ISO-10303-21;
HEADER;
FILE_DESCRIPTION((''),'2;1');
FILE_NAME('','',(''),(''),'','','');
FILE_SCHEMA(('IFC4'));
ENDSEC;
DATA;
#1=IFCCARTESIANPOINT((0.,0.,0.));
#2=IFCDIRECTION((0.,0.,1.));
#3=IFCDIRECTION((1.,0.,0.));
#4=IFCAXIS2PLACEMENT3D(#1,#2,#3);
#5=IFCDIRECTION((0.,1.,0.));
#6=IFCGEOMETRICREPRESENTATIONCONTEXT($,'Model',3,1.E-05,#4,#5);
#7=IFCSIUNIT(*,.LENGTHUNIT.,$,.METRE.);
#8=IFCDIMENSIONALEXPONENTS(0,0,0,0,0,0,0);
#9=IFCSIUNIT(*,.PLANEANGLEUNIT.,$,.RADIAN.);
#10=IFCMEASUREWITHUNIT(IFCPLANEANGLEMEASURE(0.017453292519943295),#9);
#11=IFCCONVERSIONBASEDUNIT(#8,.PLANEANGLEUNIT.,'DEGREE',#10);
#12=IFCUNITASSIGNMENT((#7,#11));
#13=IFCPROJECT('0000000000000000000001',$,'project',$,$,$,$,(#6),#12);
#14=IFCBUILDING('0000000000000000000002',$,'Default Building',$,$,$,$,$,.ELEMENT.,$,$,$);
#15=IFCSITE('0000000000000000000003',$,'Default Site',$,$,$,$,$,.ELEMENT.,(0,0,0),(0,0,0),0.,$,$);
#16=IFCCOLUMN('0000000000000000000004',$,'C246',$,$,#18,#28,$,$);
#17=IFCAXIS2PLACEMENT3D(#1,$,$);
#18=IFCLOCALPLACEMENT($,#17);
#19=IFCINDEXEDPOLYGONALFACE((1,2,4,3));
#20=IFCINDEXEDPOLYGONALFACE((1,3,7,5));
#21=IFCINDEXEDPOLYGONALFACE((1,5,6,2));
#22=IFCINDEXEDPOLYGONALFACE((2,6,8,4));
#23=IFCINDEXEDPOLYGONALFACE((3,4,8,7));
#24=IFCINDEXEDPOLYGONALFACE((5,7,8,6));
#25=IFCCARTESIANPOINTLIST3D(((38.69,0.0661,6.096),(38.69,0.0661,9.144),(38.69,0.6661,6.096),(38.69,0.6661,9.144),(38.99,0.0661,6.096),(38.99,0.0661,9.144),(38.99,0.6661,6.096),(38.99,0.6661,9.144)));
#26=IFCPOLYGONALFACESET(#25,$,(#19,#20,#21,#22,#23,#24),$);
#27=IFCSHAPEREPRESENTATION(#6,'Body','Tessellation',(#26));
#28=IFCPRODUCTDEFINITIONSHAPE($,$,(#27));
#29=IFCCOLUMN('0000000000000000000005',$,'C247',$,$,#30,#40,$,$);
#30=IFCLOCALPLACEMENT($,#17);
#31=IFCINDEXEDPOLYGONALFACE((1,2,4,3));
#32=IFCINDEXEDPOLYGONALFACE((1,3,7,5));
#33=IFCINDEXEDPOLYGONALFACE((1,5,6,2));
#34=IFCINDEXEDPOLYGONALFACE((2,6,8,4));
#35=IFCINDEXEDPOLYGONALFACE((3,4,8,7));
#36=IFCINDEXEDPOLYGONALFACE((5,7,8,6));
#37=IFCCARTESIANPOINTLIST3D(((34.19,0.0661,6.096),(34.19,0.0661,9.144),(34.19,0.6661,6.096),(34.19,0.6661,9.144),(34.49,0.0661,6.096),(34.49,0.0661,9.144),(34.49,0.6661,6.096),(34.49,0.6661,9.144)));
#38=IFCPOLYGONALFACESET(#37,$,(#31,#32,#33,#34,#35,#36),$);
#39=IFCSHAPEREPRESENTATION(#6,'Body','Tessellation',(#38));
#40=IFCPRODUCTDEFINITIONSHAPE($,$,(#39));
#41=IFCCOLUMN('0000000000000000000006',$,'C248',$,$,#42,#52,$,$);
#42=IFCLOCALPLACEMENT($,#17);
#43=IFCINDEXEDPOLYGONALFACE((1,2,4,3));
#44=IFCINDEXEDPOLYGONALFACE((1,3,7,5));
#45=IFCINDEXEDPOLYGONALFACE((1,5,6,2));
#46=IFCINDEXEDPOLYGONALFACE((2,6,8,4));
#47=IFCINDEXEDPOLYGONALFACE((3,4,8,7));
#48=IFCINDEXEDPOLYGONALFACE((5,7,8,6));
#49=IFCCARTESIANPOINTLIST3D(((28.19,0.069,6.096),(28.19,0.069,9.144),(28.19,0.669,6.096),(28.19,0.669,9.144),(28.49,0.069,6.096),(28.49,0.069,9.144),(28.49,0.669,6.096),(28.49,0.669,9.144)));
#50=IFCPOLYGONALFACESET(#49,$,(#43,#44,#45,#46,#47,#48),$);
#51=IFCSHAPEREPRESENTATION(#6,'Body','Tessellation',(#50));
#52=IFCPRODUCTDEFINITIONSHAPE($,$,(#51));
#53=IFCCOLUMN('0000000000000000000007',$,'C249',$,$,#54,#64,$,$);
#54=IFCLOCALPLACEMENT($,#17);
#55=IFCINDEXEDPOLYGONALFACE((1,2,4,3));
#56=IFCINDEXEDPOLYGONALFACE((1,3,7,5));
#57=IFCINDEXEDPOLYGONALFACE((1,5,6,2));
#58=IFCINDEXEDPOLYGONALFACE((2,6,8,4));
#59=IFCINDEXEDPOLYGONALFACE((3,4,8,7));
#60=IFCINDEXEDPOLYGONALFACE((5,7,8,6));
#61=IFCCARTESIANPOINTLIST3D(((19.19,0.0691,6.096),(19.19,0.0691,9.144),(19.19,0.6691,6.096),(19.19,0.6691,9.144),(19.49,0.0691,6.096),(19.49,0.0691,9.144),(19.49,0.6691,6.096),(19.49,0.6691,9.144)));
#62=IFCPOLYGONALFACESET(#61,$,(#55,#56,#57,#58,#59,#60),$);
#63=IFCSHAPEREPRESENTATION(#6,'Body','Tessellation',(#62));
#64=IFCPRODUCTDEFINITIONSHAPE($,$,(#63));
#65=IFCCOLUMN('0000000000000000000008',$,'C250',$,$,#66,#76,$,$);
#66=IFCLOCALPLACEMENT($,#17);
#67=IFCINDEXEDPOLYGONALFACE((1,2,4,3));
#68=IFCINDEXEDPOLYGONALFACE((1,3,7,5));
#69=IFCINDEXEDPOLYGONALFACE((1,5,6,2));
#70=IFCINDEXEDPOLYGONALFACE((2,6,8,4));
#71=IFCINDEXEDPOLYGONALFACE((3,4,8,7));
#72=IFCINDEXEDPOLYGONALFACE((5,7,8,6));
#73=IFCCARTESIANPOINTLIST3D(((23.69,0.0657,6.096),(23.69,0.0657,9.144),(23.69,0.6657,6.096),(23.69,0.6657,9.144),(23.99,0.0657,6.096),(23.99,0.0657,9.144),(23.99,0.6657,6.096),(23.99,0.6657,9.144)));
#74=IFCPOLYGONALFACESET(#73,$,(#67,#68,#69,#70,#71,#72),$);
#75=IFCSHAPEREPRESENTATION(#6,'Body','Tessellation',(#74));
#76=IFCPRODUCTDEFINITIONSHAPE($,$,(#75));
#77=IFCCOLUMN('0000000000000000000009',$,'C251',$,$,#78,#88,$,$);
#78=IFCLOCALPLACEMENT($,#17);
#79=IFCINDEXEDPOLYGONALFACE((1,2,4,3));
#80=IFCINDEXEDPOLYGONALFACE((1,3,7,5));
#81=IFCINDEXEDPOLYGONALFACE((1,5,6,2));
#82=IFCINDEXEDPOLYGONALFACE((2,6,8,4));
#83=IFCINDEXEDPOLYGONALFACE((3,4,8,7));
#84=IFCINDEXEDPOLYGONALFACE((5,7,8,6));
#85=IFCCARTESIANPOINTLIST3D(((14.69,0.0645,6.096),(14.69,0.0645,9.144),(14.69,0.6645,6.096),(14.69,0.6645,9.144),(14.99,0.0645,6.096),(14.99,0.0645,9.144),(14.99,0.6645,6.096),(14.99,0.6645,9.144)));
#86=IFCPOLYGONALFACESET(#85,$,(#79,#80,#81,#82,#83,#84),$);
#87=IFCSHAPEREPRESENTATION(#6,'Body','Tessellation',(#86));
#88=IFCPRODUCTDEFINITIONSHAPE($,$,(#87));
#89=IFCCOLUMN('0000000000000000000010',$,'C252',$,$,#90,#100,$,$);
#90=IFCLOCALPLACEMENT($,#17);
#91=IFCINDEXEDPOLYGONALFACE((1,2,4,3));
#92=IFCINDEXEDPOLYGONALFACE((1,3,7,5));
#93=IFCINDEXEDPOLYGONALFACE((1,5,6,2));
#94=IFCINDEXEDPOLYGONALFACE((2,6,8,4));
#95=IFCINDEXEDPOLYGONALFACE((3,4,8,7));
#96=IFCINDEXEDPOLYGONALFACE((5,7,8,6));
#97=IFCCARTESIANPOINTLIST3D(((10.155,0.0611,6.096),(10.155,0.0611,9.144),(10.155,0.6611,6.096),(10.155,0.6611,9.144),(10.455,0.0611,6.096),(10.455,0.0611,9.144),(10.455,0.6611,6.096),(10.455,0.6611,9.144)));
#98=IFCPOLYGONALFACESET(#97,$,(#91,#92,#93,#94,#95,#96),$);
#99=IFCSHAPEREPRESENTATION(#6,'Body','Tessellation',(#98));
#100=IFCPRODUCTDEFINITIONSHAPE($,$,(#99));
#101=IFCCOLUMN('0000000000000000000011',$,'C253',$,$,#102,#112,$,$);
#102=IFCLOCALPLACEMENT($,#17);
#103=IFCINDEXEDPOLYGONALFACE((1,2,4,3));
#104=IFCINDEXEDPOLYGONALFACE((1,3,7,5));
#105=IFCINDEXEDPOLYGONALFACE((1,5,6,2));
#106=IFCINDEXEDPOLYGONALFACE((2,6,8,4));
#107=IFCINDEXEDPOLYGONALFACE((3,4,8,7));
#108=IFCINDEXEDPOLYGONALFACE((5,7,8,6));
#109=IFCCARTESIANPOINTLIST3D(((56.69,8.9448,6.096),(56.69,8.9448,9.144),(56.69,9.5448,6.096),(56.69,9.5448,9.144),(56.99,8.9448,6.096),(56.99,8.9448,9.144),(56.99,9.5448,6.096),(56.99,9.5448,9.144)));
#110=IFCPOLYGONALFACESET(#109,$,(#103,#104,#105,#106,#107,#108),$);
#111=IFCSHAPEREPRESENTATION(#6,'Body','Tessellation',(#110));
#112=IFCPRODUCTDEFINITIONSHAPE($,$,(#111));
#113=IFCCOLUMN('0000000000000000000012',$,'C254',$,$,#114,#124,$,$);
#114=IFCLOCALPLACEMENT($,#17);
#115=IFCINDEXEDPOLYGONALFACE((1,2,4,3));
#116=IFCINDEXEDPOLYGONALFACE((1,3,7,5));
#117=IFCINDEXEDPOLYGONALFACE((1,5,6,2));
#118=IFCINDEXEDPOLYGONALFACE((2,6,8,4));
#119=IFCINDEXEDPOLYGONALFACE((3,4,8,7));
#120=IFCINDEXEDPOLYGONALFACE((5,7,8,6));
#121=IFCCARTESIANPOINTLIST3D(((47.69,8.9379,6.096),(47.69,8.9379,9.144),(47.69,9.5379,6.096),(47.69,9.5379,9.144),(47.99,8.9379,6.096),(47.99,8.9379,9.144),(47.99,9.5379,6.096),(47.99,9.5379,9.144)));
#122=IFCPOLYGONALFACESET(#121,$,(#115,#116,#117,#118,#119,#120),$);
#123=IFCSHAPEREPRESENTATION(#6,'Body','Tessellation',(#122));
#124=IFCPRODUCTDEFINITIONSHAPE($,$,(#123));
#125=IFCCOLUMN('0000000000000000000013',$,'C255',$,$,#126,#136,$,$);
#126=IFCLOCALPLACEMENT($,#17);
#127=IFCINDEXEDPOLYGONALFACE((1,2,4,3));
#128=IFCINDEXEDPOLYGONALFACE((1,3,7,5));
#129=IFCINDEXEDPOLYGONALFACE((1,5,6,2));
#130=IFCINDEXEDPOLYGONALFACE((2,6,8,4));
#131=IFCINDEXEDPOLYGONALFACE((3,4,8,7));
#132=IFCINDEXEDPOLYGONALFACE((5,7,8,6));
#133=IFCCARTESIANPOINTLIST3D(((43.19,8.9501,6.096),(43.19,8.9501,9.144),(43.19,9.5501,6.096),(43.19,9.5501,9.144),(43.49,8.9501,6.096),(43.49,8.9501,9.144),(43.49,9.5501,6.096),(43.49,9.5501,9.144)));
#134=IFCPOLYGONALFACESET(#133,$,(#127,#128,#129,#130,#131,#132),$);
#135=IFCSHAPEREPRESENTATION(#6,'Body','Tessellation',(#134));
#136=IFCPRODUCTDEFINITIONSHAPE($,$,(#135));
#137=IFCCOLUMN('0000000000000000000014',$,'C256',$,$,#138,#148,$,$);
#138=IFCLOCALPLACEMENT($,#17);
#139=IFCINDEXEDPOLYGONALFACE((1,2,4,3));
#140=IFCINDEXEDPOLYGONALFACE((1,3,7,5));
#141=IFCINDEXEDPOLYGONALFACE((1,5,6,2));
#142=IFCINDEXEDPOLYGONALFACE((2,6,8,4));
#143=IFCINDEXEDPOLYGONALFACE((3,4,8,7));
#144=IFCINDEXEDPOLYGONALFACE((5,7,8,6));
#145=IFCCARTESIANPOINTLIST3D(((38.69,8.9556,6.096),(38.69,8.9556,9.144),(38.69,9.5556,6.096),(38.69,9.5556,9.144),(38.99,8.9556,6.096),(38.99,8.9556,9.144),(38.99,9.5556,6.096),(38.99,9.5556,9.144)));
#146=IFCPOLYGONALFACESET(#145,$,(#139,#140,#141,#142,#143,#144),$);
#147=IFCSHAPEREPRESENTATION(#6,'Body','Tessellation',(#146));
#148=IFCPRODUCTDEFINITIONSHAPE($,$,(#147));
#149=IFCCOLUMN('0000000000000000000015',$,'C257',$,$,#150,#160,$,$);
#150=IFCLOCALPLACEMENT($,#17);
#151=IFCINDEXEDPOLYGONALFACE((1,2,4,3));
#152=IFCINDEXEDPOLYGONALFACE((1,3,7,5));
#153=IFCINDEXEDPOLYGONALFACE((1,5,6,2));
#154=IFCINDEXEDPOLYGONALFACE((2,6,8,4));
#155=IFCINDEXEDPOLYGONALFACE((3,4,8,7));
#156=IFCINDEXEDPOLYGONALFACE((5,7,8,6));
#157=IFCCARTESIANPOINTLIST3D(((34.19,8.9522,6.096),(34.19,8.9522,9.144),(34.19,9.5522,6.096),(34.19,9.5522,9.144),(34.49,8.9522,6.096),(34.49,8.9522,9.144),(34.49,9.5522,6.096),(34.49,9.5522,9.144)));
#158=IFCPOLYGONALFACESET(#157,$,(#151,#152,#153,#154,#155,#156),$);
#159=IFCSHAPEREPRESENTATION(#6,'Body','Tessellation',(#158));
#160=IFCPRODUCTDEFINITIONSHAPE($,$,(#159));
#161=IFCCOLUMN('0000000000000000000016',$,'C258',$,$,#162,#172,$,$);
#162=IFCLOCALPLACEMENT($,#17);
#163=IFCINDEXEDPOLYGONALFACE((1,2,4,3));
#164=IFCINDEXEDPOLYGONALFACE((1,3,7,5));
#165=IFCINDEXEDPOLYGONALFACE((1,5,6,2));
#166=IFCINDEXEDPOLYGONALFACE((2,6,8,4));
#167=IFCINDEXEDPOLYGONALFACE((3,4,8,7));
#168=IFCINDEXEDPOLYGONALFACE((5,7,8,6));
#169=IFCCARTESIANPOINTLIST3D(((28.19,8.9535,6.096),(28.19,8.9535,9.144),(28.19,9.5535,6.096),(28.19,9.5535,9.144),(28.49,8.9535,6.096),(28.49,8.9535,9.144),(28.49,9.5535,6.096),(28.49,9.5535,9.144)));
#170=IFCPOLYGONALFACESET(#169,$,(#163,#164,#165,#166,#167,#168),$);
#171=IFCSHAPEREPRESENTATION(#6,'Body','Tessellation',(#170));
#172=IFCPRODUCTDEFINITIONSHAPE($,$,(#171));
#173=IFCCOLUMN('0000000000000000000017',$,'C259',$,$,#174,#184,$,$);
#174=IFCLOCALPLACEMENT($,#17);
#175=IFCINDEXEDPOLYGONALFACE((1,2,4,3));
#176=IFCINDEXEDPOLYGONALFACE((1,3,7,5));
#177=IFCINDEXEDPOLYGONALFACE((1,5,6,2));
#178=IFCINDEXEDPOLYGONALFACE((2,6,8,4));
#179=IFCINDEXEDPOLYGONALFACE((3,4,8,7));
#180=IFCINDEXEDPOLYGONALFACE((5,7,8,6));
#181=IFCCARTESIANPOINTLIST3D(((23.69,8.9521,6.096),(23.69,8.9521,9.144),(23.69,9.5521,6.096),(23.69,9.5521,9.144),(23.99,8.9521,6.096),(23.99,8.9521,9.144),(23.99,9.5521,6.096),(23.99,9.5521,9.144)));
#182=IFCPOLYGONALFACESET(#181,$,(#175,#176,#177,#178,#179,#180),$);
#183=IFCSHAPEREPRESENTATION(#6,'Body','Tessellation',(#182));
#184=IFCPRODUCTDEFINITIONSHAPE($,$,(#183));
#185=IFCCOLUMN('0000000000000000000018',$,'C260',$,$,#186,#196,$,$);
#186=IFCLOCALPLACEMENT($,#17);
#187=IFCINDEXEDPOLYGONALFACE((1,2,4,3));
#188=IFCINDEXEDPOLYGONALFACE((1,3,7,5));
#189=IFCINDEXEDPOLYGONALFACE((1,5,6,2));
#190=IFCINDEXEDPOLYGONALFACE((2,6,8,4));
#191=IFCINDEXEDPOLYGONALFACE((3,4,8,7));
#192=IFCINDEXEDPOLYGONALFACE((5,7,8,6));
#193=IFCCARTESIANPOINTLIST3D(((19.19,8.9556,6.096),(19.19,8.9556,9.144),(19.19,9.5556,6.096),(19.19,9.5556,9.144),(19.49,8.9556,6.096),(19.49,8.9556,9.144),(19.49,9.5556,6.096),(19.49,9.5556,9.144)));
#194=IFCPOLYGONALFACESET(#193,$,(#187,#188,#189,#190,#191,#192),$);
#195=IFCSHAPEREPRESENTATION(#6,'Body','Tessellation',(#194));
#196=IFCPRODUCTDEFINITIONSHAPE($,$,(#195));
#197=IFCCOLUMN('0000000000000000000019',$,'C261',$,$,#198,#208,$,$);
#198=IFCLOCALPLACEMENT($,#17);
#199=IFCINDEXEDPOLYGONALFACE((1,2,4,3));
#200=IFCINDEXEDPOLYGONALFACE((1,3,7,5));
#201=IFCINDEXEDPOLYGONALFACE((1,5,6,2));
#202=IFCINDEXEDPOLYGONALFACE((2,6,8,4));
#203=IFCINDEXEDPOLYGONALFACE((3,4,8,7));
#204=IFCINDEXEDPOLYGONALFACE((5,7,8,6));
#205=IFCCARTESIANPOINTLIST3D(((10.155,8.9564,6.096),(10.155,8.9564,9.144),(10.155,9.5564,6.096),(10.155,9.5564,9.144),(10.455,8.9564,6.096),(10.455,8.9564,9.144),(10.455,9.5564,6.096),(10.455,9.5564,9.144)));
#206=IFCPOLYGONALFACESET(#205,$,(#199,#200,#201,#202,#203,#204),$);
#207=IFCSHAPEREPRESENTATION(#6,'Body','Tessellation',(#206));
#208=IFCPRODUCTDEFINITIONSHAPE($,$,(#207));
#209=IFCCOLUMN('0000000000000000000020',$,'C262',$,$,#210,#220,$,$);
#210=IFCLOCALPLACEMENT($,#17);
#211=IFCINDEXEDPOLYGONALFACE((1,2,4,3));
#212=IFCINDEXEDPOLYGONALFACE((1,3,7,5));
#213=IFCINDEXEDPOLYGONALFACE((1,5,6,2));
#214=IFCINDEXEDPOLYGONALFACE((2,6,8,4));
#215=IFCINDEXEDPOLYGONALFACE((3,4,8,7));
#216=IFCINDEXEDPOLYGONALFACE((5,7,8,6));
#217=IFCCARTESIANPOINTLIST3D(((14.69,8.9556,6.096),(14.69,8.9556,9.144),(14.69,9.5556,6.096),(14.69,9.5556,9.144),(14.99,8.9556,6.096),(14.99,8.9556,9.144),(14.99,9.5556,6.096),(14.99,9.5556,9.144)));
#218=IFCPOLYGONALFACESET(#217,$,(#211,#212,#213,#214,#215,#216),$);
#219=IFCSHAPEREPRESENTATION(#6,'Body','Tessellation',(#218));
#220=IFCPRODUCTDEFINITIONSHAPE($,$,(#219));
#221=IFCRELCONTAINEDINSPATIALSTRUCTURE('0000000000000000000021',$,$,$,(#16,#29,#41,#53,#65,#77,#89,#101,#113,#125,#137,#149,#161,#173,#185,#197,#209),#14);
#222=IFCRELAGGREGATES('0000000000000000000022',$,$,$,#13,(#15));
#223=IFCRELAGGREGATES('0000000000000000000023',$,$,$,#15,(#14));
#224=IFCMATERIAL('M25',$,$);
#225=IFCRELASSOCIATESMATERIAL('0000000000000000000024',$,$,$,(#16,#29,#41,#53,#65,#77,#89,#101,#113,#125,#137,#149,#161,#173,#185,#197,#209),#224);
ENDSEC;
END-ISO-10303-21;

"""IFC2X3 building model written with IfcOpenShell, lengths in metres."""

from ifc_helpers import new_model, entity, si_unit, converted_unit, direction, frame, frame_2d, origin_with_axes, place, context, project, spatial, rectangle, extrude, material, element, save


model = new_model("IFC2X3")

# Units and contexts
model_context = context("Model", 3, precision=1e-05, world=origin_with_axes(), true_north=direction((0.0, 1.0, 0.0)))
ifc_project = project(units=[si_unit("LENGTHUNIT", "METRE"), converted_unit("PLANEANGLEUNIT", "DEGREE", entity("IfcPlaneAngleMeasure", 0.017453292519943295), si_unit("PLANEANGLEUNIT", "RADIAN"), dimensions=[0, 0, 0, 0, 0, 0, 0])], contexts=[model_context])

# Site, building
site = spatial("IfcSite", under=ifc_project, Name="Default Site", CompositionType="ELEMENT", RefLatitude=(0, 0, 0), RefLongitude=(0, 0, 0), RefElevation=0.0)
building = spatial("IfcBuilding", under=site, Name="Default Building", CompositionType="ELEMENT")

# Columns
ifc_material = material(Name="M25")
placement = place(None, origin_with_axes())
element("IfcColumn", 1, at=placement, inside=building, material=ifc_material, Name="C246", context=model_context, shape_type="SweptSolid", body=[
    extrude(rectangle(XDim=0.3, YDim=0.6, at=frame_2d((0.0, 0.0), x_axis=(1.0, 0.0, 0.0))), frame((38.84, 0.3661, 6.096), z_axis=(0.0, 0.0, 1.0), x_axis=(1.0, 0.0, 0.0)), (0.0, 0.0, 1.0), 3.048),
])
element("IfcColumn", 2, at=placement, inside=building, material=ifc_material, Name="C247", context=model_context, shape_type="SweptSolid", body=[
    extrude(rectangle(XDim=0.3, YDim=0.6, at=frame_2d((0.0, 0.0), x_axis=(1.0, 0.0, 0.0))), frame((34.34, 0.3661, 6.096), z_axis=(0.0, 0.0, 1.0), x_axis=(1.0, 0.0, 0.0)), (0.0, 0.0, 1.0), 3.048),
])
element("IfcColumn", 3, at=placement, inside=building, material=ifc_material, Name="C248", context=model_context, shape_type="SweptSolid", body=[
    extrude(rectangle(XDim=0.3, YDim=0.6, at=frame_2d((0.0, 0.0), x_axis=(1.0, 0.0, 0.0))), frame((28.34, 0.369, 6.096), z_axis=(0.0, 0.0, 1.0), x_axis=(1.0, 0.0, 0.0)), (0.0, 0.0, 1.0), 3.048),
])
element("IfcColumn", 4, at=placement, inside=building, material=ifc_material, Name="C249", context=model_context, shape_type="SweptSolid", body=[
    extrude(rectangle(XDim=0.3, YDim=0.6, at=frame_2d((0.0, 0.0), x_axis=(1.0, 0.0, 0.0))), frame((19.34, 0.3691, 6.096), z_axis=(0.0, 0.0, 1.0), x_axis=(1.0, 0.0, 0.0)), (0.0, 0.0, 1.0), 3.048),
])
element("IfcColumn", 5, at=placement, inside=building, material=ifc_material, Name="C250", context=model_context, shape_type="SweptSolid", body=[
    extrude(rectangle(XDim=0.3, YDim=0.6, at=frame_2d((0.0, 0.0), x_axis=(1.0, 0.0, 0.0))), frame((23.84, 0.3657, 6.096), z_axis=(0.0, 0.0, 1.0), x_axis=(1.0, 0.0, 0.0)), (0.0, 0.0, 1.0), 3.048),
])
element("IfcColumn", 6, at=placement, inside=building, material=ifc_material, Name="C251", context=model_context, shape_type="SweptSolid", body=[
    extrude(rectangle(XDim=0.3, YDim=0.6, at=frame_2d((0.0, 0.0), x_axis=(1.0, 0.0, 0.0))), frame((14.84, 0.3645, 6.096), z_axis=(0.0, 0.0, 1.0), x_axis=(1.0, 0.0, 0.0)), (0.0, 0.0, 1.0), 3.048),
])
element("IfcColumn", 7, at=placement, inside=building, material=ifc_material, Name="C252", context=model_context, shape_type="SweptSolid", body=[
    extrude(rectangle(XDim=0.3, YDim=0.6, at=frame_2d((0.0, 0.0), x_axis=(1.0, 0.0, 0.0))), frame((10.305, 0.3611, 6.096), z_axis=(0.0, 0.0, 1.0), x_axis=(1.0, 0.0, 0.0)), (0.0, 0.0, 1.0), 3.048),
])
element("IfcColumn", 8, at=placement, inside=building, material=ifc_material, Name="C253", context=model_context, shape_type="SweptSolid", body=[
    extrude(rectangle(XDim=0.3, YDim=0.6, at=frame_2d((0.0, 0.0), x_axis=(1.0, 0.0, 0.0))), frame((56.84, 9.2448, 6.096), z_axis=(0.0, 0.0, 1.0), x_axis=(1.0, 0.0, 0.0)), (0.0, 0.0, 1.0), 3.048),
])
element("IfcColumn", 9, at=placement, inside=building, material=ifc_material, Name="C254", context=model_context, shape_type="SweptSolid", body=[
    extrude(rectangle(XDim=0.3, YDim=0.6, at=frame_2d((0.0, 0.0), x_axis=(1.0, 0.0, 0.0))), frame((47.84, 9.2379, 6.096), z_axis=(0.0, 0.0, 1.0), x_axis=(1.0, 0.0, 0.0)), (0.0, 0.0, 1.0), 3.048),
])
element("IfcColumn", 10, at=placement, inside=building, material=ifc_material, Name="C255", context=model_context, shape_type="SweptSolid", body=[
    extrude(rectangle(XDim=0.3, YDim=0.6, at=frame_2d((0.0, 0.0), x_axis=(1.0, 0.0, 0.0))), frame((43.34, 9.2501, 6.096), z_axis=(0.0, 0.0, 1.0), x_axis=(1.0, 0.0, 0.0)), (0.0, 0.0, 1.0), 3.048),
])
element("IfcColumn", 11, at=placement, inside=building, material=ifc_material, Name="C256", context=model_context, shape_type="SweptSolid", body=[
    extrude(rectangle(XDim=0.3, YDim=0.6, at=frame_2d((0.0, 0.0), x_axis=(1.0, 0.0, 0.0))), frame((38.84, 9.2556, 6.096), z_axis=(0.0, 0.0, 1.0), x_axis=(1.0, 0.0, 0.0)), (0.0, 0.0, 1.0), 3.048),
])
element("IfcColumn", 12, at=placement, inside=building, material=ifc_material, Name="C257", context=model_context, shape_type="SweptSolid", body=[
    extrude(rectangle(XDim=0.3, YDim=0.6, at=frame_2d((0.0, 0.0), x_axis=(1.0, 0.0, 0.0))), frame((34.34, 9.2522, 6.096), z_axis=(0.0, 0.0, 1.0), x_axis=(1.0, 0.0, 0.0)), (0.0, 0.0, 1.0), 3.048),
])
element("IfcColumn", 13, at=placement, inside=building, material=ifc_material, Name="C258", context=model_context, shape_type="SweptSolid", body=[
    extrude(rectangle(XDim=0.3, YDim=0.6, at=frame_2d((0.0, 0.0), x_axis=(1.0, 0.0, 0.0))), frame((28.34, 9.2535, 6.096), z_axis=(0.0, 0.0, 1.0), x_axis=(1.0, 0.0, 0.0)), (0.0, 0.0, 1.0), 3.048),
])
element("IfcColumn", 14, at=placement, inside=building, material=ifc_material, Name="C259", context=model_context, shape_type="SweptSolid", body=[
    extrude(rectangle(XDim=0.3, YDim=0.6, at=frame_2d((0.0, 0.0), x_axis=(1.0, 0.0, 0.0))), frame((23.84, 9.2521, 6.096), z_axis=(0.0, 0.0, 1.0), x_axis=(1.0, 0.0, 0.0)), (0.0, 0.0, 1.0), 3.048),
])
element("IfcColumn", 15, at=placement, inside=building, material=ifc_material, Name="C260", context=model_context, shape_type="SweptSolid", body=[
    extrude(rectangle(XDim=0.3, YDim=0.6, at=frame_2d((0.0, 0.0), x_axis=(1.0, 0.0, 0.0))), frame((19.34, 9.2556, 6.096), z_axis=(0.0, 0.0, 1.0), x_axis=(1.0, 0.0, 0.0)), (0.0, 0.0, 1.0), 3.048),
])
element("IfcColumn", 16, at=placement, inside=building, material=ifc_material, Name="C261", context=model_context, shape_type="SweptSolid", body=[
    extrude(rectangle(XDim=0.3, YDim=0.6, at=frame_2d((0.0, 0.0), x_axis=(1.0, 0.0, 0.0))), frame((10.305, 9.2564, 6.096), z_axis=(0.0, 0.0, 1.0), x_axis=(1.0, 0.0, 0.0)), (0.0, 0.0, 1.0), 3.048),
])
element("IfcColumn", 17, at=placement, inside=building, material=ifc_material, Name="C262", context=model_context, shape_type="SweptSolid", body=[
    extrude(rectangle(XDim=0.3, YDim=0.6, at=frame_2d((0.0, 0.0), x_axis=(1.0, 0.0, 0.0))), frame((14.84, 9.2556, 6.096), z_axis=(0.0, 0.0, 1.0), x_axis=(1.0, 0.0, 0.0)), (0.0, 0.0, 1.0), 3.048),
])

save(model, "model.ifc")
